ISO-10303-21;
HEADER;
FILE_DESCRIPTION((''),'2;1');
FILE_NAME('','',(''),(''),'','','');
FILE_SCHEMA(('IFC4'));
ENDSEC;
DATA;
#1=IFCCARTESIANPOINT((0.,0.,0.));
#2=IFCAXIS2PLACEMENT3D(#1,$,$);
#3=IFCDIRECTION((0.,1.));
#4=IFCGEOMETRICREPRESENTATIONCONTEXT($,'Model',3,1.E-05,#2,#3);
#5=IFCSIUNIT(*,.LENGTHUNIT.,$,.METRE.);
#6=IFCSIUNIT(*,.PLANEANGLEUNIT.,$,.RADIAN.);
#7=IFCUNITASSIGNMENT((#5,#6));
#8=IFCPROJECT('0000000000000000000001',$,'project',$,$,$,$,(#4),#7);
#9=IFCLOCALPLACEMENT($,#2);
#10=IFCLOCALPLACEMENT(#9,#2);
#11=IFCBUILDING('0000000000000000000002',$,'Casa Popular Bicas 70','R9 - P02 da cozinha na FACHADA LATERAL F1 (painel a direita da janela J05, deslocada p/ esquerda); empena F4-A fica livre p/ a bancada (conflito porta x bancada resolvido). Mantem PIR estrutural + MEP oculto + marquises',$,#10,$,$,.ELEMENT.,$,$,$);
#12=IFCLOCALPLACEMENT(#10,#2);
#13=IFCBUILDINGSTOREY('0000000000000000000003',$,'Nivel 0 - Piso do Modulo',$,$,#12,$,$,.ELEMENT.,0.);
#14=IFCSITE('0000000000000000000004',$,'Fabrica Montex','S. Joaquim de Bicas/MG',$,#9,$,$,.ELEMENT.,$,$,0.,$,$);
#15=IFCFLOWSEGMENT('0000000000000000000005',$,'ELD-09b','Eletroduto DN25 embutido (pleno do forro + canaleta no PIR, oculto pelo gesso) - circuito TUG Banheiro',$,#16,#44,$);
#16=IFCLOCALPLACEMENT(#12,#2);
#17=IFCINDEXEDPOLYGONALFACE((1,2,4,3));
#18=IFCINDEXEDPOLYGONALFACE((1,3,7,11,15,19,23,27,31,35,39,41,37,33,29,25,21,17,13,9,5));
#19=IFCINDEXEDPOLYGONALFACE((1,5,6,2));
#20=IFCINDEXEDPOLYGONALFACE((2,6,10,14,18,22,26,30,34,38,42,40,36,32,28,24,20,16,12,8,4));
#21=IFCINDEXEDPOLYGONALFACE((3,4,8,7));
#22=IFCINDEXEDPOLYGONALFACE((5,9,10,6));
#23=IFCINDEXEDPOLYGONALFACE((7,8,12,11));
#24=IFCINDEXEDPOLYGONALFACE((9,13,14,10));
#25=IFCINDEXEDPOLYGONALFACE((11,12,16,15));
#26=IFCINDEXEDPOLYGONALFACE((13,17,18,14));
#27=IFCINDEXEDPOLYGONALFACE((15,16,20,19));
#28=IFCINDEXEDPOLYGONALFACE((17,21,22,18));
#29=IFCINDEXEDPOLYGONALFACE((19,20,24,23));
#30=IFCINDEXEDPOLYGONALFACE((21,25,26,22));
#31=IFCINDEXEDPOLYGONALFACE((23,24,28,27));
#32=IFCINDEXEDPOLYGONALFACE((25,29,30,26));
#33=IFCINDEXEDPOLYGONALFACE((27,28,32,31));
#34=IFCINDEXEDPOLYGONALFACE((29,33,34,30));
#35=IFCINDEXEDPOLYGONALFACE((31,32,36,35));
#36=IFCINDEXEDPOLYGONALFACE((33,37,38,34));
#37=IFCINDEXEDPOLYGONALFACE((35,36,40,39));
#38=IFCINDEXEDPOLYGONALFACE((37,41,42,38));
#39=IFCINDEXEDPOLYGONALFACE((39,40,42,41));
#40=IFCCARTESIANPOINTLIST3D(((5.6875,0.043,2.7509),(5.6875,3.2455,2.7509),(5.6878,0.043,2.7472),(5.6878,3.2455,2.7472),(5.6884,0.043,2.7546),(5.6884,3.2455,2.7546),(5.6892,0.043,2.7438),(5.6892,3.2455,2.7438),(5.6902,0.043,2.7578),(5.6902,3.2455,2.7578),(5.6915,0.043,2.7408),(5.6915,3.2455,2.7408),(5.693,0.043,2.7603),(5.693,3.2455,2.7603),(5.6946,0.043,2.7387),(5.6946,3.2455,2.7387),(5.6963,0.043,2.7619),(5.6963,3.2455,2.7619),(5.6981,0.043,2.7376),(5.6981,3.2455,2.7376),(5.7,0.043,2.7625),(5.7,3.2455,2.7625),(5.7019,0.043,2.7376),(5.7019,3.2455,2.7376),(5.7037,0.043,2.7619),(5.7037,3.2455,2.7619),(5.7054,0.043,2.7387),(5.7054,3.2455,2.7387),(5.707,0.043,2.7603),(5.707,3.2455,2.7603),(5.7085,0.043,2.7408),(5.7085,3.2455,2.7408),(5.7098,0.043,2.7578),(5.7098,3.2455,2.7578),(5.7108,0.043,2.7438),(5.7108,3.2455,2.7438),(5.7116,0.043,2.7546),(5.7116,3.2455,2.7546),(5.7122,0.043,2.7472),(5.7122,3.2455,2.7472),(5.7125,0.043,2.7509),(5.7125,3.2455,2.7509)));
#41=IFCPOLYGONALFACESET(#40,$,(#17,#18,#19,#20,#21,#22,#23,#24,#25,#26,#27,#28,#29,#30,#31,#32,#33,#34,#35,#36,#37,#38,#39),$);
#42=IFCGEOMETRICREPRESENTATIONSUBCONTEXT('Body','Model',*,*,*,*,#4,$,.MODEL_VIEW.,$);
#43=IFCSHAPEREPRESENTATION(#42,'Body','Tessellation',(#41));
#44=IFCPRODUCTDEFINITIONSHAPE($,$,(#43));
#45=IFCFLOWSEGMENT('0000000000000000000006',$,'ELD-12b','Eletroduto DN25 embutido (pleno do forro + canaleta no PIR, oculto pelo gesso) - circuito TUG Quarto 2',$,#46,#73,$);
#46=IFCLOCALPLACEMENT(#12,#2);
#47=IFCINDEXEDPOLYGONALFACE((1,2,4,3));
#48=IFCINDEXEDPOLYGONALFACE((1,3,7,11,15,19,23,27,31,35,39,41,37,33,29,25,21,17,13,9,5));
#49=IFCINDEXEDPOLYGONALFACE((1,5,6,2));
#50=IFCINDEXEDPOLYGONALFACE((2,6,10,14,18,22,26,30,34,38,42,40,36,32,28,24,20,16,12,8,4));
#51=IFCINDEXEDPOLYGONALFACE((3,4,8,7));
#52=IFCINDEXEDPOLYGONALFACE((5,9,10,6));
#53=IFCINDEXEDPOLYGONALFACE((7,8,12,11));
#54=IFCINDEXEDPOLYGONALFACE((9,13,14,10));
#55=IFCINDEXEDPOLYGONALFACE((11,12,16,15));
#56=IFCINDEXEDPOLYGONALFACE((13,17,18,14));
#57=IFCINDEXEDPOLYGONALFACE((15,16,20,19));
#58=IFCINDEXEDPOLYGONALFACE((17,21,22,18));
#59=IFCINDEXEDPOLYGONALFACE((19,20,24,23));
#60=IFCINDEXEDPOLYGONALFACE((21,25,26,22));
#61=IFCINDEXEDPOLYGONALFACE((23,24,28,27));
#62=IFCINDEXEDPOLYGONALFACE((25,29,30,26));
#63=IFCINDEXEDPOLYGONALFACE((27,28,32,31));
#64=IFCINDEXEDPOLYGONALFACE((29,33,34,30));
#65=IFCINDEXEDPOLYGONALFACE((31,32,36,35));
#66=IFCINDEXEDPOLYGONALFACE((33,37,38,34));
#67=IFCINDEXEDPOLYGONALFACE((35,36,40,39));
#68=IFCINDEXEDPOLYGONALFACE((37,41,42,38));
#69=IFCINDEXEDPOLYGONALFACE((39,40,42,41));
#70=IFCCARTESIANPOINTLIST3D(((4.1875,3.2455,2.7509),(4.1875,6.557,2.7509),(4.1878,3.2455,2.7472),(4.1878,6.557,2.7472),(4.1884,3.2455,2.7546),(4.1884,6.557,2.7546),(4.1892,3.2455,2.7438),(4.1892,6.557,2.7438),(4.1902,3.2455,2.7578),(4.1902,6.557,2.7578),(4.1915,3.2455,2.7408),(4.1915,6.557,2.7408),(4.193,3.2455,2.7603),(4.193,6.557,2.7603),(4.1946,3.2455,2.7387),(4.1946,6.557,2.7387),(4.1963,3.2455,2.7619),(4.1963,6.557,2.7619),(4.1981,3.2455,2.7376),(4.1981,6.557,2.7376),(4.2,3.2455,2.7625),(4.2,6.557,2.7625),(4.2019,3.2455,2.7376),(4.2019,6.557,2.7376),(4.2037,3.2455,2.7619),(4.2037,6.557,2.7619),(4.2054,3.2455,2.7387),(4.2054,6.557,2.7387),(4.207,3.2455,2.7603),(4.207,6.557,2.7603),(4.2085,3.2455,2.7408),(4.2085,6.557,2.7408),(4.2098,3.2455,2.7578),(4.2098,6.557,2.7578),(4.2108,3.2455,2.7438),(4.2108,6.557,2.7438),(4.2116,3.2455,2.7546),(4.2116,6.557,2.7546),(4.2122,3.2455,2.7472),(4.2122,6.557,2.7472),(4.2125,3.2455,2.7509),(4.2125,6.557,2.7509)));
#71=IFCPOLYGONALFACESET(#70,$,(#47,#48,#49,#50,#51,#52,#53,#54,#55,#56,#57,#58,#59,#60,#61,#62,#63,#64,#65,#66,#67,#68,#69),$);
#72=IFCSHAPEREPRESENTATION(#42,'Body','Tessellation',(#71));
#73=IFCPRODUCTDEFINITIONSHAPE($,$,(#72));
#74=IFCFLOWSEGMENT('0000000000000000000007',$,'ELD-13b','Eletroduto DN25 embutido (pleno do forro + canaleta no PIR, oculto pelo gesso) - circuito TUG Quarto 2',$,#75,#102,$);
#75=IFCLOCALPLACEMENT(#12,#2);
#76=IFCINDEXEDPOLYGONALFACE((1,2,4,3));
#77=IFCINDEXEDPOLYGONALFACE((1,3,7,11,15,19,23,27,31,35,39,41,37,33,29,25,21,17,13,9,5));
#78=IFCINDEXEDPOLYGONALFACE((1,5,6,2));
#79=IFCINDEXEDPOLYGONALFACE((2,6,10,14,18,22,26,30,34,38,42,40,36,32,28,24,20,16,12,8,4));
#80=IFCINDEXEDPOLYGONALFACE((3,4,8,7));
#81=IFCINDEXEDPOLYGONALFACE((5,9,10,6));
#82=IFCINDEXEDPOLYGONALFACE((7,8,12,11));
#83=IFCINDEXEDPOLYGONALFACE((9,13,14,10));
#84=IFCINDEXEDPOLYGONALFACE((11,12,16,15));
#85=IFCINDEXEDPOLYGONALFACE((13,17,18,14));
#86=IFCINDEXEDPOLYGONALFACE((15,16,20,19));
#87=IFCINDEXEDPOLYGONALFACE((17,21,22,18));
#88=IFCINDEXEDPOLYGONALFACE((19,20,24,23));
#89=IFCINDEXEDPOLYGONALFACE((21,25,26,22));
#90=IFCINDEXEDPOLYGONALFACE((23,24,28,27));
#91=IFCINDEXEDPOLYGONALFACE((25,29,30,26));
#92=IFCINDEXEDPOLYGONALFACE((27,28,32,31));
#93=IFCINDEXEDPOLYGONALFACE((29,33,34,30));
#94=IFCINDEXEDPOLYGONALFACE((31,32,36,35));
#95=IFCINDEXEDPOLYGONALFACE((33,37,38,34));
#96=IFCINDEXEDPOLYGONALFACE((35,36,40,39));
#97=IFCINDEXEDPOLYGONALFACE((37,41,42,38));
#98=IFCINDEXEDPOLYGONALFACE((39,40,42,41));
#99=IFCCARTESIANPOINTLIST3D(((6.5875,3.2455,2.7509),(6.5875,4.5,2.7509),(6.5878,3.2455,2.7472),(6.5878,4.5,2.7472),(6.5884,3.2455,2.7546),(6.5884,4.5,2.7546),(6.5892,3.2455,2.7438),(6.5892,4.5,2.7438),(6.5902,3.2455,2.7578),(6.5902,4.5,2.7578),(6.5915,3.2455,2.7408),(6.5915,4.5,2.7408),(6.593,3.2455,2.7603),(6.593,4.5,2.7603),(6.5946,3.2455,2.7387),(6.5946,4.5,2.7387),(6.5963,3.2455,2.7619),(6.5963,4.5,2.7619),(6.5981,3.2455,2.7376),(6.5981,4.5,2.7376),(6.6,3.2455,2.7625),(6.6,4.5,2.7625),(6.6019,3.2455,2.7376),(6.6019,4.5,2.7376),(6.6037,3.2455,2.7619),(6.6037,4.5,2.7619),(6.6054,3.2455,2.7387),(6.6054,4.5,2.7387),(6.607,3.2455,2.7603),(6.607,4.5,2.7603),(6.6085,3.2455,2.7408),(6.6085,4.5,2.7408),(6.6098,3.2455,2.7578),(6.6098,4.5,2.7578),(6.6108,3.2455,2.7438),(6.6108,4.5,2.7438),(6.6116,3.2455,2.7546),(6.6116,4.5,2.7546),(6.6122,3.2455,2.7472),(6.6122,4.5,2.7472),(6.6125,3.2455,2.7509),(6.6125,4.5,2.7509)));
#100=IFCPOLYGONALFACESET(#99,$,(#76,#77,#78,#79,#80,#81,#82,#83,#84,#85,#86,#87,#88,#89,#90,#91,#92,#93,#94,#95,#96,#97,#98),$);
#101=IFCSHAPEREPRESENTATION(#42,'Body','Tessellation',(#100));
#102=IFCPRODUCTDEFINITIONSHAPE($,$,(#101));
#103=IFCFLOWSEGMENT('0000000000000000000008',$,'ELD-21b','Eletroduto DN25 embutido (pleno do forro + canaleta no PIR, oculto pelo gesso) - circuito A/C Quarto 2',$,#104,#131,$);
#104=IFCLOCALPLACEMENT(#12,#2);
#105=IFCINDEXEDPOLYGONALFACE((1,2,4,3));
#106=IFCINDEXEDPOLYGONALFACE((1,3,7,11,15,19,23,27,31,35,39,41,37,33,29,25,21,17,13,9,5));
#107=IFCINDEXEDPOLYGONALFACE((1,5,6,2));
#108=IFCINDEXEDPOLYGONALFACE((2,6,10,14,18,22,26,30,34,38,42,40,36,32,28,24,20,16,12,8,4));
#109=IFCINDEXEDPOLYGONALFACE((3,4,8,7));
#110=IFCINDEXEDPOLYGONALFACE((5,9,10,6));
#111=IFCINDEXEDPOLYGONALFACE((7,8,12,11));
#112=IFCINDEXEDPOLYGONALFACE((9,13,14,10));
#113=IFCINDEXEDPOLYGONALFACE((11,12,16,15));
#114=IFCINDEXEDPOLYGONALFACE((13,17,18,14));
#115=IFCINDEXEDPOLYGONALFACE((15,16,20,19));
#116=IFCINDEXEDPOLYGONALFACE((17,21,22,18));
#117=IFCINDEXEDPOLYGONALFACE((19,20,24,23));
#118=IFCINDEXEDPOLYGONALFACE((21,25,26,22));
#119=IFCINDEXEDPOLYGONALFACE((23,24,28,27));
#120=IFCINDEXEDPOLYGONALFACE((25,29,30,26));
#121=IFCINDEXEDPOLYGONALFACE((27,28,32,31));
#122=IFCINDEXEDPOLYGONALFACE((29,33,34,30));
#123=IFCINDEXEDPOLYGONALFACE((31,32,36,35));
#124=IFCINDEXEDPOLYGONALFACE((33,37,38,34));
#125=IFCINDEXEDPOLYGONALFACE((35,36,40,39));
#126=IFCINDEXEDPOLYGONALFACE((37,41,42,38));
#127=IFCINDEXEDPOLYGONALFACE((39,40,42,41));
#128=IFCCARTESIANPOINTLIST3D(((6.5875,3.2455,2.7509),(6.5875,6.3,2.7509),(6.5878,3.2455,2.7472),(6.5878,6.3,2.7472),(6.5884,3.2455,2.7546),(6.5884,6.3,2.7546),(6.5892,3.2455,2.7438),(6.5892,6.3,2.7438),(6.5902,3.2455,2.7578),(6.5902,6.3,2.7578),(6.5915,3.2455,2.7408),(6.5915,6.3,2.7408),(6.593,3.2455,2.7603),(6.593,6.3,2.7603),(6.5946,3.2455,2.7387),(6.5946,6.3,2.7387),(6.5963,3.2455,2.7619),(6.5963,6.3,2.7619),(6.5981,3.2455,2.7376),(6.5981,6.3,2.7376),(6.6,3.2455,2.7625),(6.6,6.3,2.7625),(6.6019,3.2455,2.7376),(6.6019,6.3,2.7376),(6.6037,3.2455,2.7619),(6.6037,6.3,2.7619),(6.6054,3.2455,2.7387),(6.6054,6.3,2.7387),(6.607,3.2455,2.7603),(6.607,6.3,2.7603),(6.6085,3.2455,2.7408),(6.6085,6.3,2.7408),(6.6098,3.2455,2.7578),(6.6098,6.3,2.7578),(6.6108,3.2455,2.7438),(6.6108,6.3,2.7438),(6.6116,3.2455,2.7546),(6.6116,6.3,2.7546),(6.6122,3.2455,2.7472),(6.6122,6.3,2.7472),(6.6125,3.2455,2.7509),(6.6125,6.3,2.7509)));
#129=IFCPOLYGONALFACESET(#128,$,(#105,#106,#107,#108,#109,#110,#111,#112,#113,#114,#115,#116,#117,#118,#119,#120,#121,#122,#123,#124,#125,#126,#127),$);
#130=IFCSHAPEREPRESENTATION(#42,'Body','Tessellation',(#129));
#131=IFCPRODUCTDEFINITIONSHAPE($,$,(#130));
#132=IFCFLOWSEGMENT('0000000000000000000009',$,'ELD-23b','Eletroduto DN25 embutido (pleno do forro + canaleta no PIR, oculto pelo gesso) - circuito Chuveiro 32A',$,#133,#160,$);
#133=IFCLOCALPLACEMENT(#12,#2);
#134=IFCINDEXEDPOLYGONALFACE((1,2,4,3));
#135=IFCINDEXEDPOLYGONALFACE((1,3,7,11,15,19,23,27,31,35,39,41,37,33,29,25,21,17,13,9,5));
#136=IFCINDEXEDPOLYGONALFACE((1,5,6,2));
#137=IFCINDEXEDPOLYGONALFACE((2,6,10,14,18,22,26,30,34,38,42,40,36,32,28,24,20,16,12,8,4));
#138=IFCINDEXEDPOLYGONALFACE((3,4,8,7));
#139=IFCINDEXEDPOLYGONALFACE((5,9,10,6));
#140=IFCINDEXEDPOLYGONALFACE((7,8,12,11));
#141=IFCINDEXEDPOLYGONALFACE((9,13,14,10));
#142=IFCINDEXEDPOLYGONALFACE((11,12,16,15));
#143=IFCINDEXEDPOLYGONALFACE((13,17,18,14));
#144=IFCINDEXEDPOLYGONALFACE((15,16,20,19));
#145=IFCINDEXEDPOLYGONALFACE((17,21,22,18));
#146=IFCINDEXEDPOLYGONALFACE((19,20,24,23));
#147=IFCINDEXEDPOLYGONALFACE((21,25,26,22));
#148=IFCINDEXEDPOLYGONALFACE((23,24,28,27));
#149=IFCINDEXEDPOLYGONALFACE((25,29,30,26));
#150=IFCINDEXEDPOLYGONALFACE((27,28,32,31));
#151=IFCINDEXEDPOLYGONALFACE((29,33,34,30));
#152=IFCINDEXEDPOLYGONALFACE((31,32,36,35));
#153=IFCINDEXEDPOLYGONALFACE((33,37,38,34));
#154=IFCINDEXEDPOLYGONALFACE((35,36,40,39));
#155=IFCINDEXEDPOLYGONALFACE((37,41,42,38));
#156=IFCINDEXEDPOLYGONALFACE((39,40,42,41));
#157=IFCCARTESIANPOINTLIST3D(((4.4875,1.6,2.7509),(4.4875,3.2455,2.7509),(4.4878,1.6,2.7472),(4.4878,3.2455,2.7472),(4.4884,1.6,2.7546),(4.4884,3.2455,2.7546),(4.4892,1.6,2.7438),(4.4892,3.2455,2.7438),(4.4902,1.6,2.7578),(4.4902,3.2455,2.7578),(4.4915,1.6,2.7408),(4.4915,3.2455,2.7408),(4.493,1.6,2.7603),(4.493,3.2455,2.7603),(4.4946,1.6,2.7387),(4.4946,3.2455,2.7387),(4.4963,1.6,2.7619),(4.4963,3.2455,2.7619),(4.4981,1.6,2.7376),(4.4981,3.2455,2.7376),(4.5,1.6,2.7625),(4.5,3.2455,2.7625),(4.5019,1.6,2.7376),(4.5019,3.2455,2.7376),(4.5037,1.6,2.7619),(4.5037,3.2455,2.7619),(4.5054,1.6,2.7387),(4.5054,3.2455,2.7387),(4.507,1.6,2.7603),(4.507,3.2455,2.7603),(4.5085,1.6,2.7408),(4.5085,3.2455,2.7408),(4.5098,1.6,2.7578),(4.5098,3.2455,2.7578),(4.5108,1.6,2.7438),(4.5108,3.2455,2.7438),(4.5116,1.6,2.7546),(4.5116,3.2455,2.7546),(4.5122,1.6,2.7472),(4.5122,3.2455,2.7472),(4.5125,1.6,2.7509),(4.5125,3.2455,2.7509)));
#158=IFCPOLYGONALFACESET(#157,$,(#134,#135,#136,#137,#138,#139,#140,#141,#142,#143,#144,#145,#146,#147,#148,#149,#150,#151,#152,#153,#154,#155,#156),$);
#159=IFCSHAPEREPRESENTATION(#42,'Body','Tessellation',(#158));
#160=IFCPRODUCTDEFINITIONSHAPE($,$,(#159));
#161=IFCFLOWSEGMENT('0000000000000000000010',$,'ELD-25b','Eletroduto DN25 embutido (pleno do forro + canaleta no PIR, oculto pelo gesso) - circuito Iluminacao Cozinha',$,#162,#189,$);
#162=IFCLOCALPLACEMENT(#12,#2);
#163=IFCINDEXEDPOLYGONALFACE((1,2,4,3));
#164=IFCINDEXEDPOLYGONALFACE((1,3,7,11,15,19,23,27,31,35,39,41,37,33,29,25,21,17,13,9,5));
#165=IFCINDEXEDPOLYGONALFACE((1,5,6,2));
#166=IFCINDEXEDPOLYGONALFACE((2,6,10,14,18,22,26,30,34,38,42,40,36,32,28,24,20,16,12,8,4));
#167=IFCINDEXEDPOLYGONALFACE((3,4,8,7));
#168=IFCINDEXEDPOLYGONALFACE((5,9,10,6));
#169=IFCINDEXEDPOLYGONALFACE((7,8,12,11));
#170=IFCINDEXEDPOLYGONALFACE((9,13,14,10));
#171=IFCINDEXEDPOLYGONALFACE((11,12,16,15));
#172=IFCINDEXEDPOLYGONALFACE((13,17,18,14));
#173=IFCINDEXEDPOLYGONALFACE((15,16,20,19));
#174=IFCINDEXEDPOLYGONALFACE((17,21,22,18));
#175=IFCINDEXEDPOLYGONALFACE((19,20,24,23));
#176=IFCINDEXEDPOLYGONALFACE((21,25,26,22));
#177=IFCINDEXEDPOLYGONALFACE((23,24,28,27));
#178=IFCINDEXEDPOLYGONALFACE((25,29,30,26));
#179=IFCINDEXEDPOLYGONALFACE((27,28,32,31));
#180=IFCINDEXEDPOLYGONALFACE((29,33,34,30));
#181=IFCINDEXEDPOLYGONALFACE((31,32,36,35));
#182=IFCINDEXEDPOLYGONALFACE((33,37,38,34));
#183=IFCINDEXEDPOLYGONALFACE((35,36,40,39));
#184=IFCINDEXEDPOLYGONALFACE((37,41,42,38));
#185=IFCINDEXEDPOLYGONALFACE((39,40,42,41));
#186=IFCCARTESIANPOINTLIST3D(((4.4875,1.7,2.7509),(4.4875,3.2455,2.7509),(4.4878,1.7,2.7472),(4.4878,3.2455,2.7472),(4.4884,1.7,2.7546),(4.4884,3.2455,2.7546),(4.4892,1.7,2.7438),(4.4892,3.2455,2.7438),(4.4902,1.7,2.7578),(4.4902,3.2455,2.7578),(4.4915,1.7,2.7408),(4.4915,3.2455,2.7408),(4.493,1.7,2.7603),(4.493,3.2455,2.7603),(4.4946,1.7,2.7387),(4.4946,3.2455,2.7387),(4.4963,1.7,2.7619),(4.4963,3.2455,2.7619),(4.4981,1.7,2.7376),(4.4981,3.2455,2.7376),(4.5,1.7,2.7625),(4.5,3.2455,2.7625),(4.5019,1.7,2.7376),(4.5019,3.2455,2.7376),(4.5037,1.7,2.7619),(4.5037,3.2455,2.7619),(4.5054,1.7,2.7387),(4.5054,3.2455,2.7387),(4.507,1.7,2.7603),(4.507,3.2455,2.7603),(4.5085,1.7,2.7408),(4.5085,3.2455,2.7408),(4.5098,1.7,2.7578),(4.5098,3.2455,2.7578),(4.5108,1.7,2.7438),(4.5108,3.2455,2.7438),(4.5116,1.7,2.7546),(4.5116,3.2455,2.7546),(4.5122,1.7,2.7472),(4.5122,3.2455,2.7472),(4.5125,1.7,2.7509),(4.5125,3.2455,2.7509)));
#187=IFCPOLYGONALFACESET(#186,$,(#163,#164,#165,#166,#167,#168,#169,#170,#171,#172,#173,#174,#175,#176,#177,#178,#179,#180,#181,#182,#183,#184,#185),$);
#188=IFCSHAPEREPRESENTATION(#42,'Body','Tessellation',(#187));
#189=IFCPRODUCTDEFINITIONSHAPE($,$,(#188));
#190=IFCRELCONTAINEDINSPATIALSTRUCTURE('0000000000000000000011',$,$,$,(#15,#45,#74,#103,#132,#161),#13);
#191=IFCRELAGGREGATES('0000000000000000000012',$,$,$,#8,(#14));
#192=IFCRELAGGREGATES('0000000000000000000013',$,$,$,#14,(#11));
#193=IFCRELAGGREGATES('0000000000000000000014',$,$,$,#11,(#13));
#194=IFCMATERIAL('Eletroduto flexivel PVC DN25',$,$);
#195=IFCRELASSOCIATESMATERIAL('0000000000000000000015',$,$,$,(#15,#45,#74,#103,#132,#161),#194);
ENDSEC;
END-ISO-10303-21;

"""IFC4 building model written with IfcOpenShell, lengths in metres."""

from ifc_helpers import new_model, si_unit, direction, frame, origin, origin_2d, place, context, subcontext, project, spatial, circle, extrude, material, element, save


model = new_model("IFC4")

# Units and contexts
model_context_1 = context("Model", 3, precision=1e-05, world=origin(), true_north=direction((0.0, 1.0)))
body_context_1 = subcontext(model_context_1, "Body", "Model", "MODEL_VIEW")
ifc_project = project(units=[si_unit("LENGTHUNIT", "METRE"), si_unit("PLANEANGLEUNIT", "RADIAN")], contexts=[model_context_1])

# Site, building, storey
site_placement = place(None, origin())
site = spatial("IfcSite", under=ifc_project, at=site_placement, Name="Fabrica Montex", Description="S. Joaquim de Bicas/MG", CompositionType="ELEMENT", RefElevation=0.0)
building_placement = place(site_placement, origin())
building = spatial("IfcBuilding", under=site, at=building_placement, Name="Casa Popular Bicas 70", Description="R9 - P02 da cozinha na FACHADA LATERAL F1 (painel a direita da janela J05, deslocada p/ esquerda); empena F4-A fica livre p/ a bancada (conflito porta x bancada resolvido). Mantem PIR estrutural + MEP oculto + marquises", CompositionType="ELEMENT")
storey_placement = place(building_placement, origin())
storey = spatial("IfcBuildingStorey", under=building, at=storey_placement, Name="Nivel 0 - Piso do Modulo", CompositionType="ELEMENT", Elevation=0.0)

# Flow segments
ifc_material_1 = material(Name="Eletroduto flexivel PVC DN25")
for number, where, z_axis, x_axis, name in (
    (1, (5.7, 3.2455, 2.75), (0.0, -1.0, 0.0), (0.0, 0.0, 1.0), "ELD-09b"),
):
    element("IfcFlowSegment", number, at=place(storey_placement, frame(where, z_axis=z_axis, x_axis=x_axis)), inside=storey, material=ifc_material_1, Name=name, Description="Eletroduto DN25 embutido (pleno do forro + canaleta no PIR, oculto pelo gesso) - circuito TUG Banheiro", context=body_context_1, shape_type="SweptSolid", body=[
        extrude(circle(Radius=0.0125, at=origin_2d()), origin(), (0.0, 0.0, 1.0), 3.2025),
    ])
flow_segment_1_placement = place(storey_placement, frame((4.2, 3.2455, 2.75), z_axis=(0.0, 1.0, 0.0), x_axis=(0.0, 0.0, 1.0)))
element("IfcFlowSegment", 2, at=flow_segment_1_placement, inside=storey, material=ifc_material_1, Name="ELD-12b", Description="Eletroduto DN25 embutido (pleno do forro + canaleta no PIR, oculto pelo gesso) - circuito TUG Quarto 2", context=body_context_1, shape_type="SweptSolid", body=[
    extrude(circle(Radius=0.0125, at=origin_2d()), origin(), (0.0, 0.0, 1.0), 3.3115),
])
flow_segment_2_placement = place(storey_placement, frame((6.6, 3.2455, 2.75), z_axis=(0.0, 1.0, 0.0), x_axis=(0.0, 0.0, 1.0)))
element("IfcFlowSegment", 3, at=flow_segment_2_placement, inside=storey, material=ifc_material_1, Name="ELD-13b", Description="Eletroduto DN25 embutido (pleno do forro + canaleta no PIR, oculto pelo gesso) - circuito TUG Quarto 2", context=body_context_1, shape_type="SweptSolid", body=[
    extrude(circle(Radius=0.0125, at=origin_2d()), origin(), (0.0, 0.0, 1.0), 1.2545),
])
flow_segment_3_placement = place(storey_placement, frame((6.6, 3.2455, 2.75), z_axis=(0.0, 1.0, 0.0), x_axis=(0.0, 0.0, 1.0)))
element("IfcFlowSegment", 4, at=flow_segment_3_placement, inside=storey, material=ifc_material_1, Name="ELD-21b", Description="Eletroduto DN25 embutido (pleno do forro + canaleta no PIR, oculto pelo gesso) - circuito A/C Quarto 2", context=body_context_1, shape_type="SweptSolid", body=[
    extrude(circle(Radius=0.0125, at=origin_2d()), origin(), (0.0, 0.0, 1.0), 3.0545),
])
flow_segment_4_placement = place(storey_placement, frame((4.5, 3.2455, 2.75), z_axis=(0.0, -1.0, 0.0), x_axis=(0.0, 0.0, 1.0)))
element("IfcFlowSegment", 5, at=flow_segment_4_placement, inside=storey, material=ifc_material_1, Name="ELD-23b", Description="Eletroduto DN25 embutido (pleno do forro + canaleta no PIR, oculto pelo gesso) - circuito Chuveiro 32A", context=body_context_1, shape_type="SweptSolid", body=[
    extrude(circle(Radius=0.0125, at=origin_2d()), origin(), (0.0, 0.0, 1.0), 1.6455),
])
flow_segment_5_placement = place(storey_placement, frame((4.5, 3.2455, 2.75), z_axis=(0.0, -1.0, 0.0), x_axis=(0.0, 0.0, 1.0)))
element("IfcFlowSegment", 6, at=flow_segment_5_placement, inside=storey, material=ifc_material_1, Name="ELD-25b", Description="Eletroduto DN25 embutido (pleno do forro + canaleta no PIR, oculto pelo gesso) - circuito Iluminacao Cozinha", context=body_context_1, shape_type="SweptSolid", body=[
    extrude(circle(Radius=0.0125, at=origin_2d()), origin(), (0.0, 0.0, 1.0), 1.5455),
])

save(model, "model.ifc")
